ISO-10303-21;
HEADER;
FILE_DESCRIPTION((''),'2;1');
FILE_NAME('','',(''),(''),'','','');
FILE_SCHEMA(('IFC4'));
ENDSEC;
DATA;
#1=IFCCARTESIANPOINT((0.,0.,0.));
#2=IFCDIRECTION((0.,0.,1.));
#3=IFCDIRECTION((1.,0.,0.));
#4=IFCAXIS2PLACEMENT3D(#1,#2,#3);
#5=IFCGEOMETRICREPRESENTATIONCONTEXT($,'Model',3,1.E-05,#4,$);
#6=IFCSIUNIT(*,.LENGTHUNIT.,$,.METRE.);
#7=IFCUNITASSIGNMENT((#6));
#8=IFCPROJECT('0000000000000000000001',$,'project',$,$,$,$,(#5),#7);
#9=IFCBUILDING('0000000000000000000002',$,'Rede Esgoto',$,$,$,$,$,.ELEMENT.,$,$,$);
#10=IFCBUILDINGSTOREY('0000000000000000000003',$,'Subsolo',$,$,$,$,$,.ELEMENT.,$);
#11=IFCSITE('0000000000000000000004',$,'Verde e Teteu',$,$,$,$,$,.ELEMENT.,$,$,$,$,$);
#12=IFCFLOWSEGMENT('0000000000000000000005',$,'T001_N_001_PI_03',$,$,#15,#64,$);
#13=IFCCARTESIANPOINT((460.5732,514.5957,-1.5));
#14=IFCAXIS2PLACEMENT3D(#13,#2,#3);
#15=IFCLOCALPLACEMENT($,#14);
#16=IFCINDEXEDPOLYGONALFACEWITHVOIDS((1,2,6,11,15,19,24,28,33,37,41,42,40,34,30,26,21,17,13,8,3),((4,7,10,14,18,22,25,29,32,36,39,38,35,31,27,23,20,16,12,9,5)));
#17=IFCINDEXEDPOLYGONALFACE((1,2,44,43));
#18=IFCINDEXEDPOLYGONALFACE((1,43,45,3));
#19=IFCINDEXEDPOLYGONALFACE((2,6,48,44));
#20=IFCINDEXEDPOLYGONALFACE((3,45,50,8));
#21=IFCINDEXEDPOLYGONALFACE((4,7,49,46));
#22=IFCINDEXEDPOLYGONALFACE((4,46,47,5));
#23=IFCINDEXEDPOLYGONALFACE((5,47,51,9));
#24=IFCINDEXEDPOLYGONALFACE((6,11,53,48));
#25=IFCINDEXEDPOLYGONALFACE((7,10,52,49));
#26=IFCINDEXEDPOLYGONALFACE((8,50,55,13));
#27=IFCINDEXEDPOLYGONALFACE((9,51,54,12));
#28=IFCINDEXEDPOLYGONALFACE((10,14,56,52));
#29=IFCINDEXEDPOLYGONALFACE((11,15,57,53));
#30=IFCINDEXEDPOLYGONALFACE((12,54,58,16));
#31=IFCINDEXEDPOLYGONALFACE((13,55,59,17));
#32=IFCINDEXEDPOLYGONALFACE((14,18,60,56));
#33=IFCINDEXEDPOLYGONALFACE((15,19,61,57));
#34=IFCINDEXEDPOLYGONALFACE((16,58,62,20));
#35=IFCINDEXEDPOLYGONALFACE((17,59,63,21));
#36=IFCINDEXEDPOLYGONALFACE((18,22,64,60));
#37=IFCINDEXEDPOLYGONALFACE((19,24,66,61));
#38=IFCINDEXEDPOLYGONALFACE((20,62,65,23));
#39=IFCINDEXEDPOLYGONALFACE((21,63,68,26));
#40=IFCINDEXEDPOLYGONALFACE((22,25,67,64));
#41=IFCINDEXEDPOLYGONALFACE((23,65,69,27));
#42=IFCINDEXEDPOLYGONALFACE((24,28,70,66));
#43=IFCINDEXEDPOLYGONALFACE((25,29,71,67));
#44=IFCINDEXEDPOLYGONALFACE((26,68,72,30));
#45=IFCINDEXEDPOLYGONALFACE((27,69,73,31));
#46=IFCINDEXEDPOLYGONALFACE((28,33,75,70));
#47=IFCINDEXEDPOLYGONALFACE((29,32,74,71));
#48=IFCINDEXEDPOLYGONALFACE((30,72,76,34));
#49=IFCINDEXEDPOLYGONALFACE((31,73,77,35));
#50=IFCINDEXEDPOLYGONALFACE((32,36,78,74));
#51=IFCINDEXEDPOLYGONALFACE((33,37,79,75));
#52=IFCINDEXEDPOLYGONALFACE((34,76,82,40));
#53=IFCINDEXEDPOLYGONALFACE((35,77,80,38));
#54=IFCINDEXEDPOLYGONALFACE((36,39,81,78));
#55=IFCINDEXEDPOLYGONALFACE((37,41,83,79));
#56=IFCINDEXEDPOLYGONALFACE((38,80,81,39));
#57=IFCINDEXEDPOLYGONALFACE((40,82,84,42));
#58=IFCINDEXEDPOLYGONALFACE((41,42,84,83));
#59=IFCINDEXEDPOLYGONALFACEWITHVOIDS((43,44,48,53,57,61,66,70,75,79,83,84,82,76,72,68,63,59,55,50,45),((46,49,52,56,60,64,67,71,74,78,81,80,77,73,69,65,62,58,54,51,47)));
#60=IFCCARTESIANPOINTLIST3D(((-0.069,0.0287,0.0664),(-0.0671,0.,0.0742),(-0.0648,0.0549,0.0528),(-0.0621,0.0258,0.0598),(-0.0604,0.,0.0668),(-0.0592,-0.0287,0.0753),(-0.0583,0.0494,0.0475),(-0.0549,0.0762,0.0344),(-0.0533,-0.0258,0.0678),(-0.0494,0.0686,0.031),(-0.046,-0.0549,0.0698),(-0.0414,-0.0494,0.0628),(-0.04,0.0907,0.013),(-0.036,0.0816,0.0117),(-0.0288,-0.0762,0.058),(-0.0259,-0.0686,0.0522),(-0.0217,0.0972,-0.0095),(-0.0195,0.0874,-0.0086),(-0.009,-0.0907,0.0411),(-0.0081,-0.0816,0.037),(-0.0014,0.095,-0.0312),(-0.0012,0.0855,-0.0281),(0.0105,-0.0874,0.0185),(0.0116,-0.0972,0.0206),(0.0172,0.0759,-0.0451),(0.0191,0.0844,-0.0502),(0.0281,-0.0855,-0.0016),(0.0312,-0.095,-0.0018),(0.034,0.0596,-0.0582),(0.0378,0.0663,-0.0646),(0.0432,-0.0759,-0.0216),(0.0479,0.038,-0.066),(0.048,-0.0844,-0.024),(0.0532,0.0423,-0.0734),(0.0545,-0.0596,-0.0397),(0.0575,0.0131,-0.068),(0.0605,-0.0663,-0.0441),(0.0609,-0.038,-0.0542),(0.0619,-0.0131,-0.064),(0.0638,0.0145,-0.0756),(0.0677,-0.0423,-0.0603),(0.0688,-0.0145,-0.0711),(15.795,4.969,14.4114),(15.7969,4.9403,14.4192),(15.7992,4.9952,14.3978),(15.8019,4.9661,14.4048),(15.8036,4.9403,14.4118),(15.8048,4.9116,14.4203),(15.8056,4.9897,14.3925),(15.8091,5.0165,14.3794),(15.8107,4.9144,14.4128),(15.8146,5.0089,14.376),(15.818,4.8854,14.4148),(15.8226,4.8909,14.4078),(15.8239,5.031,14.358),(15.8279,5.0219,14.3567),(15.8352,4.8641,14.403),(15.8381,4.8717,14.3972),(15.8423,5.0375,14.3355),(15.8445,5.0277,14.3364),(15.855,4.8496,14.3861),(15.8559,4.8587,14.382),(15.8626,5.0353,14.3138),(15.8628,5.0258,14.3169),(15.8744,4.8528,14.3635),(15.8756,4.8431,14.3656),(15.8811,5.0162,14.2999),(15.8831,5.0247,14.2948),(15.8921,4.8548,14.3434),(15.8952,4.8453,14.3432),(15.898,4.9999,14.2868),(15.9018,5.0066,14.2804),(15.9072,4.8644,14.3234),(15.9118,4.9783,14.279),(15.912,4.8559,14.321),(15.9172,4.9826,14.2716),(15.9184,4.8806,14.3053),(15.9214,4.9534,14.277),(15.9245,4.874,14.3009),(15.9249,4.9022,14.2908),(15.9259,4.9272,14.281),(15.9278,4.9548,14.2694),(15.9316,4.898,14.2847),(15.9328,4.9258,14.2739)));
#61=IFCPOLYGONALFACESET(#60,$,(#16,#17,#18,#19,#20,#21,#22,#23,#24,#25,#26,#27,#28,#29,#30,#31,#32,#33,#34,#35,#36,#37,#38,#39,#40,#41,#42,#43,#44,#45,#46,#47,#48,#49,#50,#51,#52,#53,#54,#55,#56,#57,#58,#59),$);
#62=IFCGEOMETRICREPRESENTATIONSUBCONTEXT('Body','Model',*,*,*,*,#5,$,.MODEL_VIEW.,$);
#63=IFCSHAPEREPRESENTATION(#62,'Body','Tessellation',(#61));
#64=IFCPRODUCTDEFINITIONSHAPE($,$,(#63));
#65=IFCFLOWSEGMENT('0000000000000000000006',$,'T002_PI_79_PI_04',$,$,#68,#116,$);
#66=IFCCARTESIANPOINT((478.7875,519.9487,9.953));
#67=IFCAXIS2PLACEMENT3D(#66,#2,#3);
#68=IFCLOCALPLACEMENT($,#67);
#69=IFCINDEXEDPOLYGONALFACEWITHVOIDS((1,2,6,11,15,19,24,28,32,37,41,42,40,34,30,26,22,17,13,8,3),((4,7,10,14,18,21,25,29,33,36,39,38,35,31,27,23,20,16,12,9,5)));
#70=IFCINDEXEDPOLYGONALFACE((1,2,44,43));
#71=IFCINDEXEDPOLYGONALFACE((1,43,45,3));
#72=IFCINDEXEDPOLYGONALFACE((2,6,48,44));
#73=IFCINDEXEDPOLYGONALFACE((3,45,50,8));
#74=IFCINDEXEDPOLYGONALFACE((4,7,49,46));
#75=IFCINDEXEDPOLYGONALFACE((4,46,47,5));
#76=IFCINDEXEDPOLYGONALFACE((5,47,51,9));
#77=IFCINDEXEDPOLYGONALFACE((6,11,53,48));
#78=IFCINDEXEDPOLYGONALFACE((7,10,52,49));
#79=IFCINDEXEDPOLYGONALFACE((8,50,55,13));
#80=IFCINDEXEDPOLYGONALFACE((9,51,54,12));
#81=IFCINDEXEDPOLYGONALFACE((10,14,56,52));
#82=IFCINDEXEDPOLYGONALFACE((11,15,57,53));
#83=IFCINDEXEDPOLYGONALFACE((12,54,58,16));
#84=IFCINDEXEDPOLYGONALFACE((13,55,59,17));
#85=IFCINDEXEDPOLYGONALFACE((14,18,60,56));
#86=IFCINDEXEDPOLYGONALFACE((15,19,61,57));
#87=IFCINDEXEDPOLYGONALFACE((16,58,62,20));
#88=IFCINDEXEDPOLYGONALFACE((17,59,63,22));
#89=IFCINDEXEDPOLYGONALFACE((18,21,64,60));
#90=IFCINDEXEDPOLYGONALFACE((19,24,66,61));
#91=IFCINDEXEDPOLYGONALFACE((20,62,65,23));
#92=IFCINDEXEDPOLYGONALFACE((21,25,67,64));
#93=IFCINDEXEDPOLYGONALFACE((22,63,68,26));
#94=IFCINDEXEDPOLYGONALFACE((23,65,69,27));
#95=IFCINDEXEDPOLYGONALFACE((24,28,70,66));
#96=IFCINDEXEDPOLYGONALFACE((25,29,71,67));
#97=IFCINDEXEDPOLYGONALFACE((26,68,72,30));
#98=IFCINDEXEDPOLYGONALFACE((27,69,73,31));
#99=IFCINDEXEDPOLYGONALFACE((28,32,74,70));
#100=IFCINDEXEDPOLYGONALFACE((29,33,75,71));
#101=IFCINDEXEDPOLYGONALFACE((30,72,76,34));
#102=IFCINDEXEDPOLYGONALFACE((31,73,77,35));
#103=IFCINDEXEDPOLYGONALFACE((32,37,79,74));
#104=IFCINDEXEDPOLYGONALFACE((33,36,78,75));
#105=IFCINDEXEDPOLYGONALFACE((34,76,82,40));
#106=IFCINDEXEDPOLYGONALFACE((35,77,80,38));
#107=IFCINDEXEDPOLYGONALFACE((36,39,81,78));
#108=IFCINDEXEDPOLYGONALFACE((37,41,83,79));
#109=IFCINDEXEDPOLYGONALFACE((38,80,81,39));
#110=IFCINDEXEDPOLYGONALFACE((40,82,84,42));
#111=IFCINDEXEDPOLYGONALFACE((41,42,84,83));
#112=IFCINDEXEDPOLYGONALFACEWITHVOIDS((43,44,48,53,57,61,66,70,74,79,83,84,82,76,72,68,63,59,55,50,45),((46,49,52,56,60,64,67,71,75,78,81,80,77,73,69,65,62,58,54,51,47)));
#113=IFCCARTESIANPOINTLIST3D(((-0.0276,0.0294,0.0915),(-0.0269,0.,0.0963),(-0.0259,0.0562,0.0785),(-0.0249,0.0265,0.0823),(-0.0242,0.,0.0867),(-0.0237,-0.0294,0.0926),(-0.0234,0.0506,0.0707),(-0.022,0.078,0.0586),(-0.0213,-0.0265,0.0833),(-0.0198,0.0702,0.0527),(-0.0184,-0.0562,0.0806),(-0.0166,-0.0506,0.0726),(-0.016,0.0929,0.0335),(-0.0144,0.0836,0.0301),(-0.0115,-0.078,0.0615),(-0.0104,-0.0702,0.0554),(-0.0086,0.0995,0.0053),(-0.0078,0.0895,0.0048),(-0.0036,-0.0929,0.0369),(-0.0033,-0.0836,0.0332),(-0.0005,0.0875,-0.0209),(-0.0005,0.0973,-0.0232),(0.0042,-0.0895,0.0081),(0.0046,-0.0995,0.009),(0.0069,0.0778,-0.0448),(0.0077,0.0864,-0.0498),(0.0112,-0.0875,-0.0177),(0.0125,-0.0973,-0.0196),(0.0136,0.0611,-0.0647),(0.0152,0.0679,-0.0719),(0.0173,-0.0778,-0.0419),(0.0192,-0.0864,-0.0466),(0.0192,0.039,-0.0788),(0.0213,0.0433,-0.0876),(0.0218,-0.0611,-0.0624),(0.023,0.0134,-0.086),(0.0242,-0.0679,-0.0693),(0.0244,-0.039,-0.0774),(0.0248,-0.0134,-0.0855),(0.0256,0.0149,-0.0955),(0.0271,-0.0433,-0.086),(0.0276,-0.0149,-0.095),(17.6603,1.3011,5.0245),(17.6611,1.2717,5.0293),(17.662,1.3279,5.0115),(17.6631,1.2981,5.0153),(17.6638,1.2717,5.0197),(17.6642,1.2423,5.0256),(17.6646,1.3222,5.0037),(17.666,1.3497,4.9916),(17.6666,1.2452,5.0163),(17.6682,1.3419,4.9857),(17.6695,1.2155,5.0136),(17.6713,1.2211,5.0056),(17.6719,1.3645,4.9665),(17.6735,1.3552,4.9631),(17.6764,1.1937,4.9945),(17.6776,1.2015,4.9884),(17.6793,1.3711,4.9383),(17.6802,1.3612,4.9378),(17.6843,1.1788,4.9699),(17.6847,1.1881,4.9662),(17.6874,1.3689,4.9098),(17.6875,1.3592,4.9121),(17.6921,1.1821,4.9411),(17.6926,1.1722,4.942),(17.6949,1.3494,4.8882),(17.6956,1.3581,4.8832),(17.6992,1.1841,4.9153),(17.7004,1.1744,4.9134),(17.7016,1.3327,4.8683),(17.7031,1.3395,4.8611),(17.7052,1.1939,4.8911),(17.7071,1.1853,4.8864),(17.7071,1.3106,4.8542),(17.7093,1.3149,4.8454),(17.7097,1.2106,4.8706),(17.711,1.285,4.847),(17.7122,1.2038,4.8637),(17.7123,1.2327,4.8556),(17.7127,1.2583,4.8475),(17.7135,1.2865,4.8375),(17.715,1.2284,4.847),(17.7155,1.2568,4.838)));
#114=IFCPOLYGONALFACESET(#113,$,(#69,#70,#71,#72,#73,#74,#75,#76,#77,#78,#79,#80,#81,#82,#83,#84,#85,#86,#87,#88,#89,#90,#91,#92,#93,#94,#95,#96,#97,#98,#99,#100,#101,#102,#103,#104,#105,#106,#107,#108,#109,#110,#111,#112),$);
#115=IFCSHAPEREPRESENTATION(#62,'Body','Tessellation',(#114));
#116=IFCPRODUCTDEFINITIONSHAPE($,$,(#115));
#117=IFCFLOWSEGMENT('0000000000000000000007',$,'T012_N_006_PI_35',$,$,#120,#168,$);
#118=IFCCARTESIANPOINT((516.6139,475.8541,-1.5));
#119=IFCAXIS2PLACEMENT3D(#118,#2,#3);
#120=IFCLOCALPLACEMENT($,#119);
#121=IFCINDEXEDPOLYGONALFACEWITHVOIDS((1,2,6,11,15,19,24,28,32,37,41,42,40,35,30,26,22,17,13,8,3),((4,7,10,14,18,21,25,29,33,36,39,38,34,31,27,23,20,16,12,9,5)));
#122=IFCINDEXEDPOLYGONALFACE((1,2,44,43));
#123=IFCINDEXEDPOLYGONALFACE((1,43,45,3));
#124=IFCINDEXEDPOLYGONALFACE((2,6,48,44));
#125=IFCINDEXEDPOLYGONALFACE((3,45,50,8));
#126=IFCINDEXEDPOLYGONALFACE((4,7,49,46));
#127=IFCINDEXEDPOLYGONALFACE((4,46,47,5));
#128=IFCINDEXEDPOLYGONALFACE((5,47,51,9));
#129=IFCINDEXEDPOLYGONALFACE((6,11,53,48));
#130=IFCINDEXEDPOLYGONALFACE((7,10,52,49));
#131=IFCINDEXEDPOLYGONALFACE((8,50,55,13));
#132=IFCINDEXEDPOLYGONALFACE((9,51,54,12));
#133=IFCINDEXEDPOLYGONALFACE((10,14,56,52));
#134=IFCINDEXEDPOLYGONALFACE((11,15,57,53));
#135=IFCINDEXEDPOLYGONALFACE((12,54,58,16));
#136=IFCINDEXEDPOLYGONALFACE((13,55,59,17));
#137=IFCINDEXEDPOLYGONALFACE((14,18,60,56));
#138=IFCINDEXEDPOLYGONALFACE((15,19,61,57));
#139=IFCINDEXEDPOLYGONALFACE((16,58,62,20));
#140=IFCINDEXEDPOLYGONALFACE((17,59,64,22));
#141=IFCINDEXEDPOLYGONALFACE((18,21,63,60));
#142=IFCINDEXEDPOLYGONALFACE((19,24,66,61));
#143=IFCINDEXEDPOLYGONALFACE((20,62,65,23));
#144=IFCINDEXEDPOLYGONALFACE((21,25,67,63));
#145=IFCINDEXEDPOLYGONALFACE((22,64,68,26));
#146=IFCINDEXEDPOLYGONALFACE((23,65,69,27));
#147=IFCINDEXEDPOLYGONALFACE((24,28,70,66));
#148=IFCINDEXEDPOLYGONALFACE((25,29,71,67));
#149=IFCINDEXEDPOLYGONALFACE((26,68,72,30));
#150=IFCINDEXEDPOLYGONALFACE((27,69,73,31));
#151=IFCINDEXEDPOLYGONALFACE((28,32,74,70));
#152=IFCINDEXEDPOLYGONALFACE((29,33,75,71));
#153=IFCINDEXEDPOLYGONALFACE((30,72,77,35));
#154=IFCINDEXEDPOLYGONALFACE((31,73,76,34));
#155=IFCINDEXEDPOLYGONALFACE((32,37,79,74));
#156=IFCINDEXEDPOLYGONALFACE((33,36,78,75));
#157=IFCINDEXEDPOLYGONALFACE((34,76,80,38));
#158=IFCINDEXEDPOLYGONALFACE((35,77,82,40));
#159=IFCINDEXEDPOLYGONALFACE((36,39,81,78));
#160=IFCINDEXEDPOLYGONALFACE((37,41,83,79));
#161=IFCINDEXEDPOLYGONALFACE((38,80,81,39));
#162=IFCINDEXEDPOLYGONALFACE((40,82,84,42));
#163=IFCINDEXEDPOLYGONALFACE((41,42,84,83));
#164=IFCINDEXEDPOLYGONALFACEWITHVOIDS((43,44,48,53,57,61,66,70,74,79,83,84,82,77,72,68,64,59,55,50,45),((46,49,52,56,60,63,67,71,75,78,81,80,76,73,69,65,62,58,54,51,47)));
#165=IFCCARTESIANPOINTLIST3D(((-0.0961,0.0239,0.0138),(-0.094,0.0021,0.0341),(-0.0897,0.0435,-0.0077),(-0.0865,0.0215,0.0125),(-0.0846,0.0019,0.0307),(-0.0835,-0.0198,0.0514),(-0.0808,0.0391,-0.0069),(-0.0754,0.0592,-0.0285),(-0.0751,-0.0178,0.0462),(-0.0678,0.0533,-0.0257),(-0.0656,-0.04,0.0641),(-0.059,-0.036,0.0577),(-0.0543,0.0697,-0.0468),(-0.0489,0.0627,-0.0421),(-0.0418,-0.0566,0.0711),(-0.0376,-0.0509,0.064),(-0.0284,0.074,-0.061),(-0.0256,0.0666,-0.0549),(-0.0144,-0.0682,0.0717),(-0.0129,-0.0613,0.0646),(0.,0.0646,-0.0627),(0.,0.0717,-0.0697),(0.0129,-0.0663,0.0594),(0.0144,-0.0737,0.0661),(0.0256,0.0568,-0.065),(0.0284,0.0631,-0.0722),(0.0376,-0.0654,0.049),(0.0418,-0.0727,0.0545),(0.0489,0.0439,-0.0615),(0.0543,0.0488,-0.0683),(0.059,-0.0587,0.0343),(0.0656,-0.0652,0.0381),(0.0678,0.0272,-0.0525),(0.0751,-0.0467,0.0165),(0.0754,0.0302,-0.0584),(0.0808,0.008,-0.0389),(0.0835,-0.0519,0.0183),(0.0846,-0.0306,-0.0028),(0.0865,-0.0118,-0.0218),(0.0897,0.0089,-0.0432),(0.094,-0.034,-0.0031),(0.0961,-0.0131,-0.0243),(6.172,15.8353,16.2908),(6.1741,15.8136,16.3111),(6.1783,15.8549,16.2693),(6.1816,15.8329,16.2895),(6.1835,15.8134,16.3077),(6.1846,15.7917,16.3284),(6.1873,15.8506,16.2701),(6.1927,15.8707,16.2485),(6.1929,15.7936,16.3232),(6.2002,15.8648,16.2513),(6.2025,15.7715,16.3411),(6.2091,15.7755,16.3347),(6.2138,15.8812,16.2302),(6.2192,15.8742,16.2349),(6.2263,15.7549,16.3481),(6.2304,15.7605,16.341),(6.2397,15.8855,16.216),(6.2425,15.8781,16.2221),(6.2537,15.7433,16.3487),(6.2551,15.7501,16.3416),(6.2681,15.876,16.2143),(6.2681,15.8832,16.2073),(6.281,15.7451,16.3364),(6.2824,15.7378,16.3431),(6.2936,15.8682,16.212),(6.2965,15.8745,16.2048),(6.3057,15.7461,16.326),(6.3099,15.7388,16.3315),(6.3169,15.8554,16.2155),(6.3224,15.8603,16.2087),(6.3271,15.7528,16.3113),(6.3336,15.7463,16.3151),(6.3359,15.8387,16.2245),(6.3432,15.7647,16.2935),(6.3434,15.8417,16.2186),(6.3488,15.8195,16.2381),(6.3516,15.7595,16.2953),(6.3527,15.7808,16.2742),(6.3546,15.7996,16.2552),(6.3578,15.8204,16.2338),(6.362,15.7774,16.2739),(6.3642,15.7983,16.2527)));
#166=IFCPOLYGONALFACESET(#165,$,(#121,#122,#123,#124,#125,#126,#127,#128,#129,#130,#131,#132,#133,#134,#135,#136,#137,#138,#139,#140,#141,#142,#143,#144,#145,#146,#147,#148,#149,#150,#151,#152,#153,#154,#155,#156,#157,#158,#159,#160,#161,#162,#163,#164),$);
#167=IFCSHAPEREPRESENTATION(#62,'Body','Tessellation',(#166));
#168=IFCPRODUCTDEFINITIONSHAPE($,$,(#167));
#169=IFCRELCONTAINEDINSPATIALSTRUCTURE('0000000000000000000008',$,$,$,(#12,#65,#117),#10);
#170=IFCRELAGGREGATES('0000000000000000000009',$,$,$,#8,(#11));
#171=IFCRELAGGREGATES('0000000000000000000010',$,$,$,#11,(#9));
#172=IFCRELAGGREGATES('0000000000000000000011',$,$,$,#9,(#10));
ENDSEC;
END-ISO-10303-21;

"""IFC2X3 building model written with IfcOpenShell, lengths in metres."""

from ifc_helpers import new_model, entity, si_unit, frame, origin_with_axes, place, context, subcontext, project, spatial, element, save


model = new_model("IFC2X3")

# Units and contexts
model_context = context("Model", 3, precision=1e-05, world=origin_with_axes())
body_context = subcontext(model_context, "Body", "Model", "MODEL_VIEW")
ifc_project = project(units=[si_unit("LENGTHUNIT", "METRE")], contexts=[model_context])

# Site, building, storey
site = spatial("IfcSite", under=ifc_project, Name="Verde e Teteu", CompositionType="ELEMENT")
building = spatial("IfcBuilding", under=site, Name="Rede Esgoto", CompositionType="ELEMENT")
storey = spatial("IfcBuildingStorey", under=building, Name="Subsolo", CompositionType="ELEMENT")

# Flow segments
flow_segment_1_placement = place(None, frame((460.5732, 514.5957, -1.5), z_axis=(0.0, 0.0, 1.0), x_axis=(1.0, 0.0, 0.0)))
element("IfcFlowSegment", 1, at=flow_segment_1_placement, inside=storey, Name="T001_N_001_PI_03", context=body_context, shape_type="SweptSolid", body=[
    entity("IfcSweptDiskSolid", entity("IfcPolyline", [entity("IfcCartesianPoint", [0.0, 0.0, 0.0]), entity("IfcCartesianPoint", [15.864, 4.9403, 14.345])]), 0.1, 0.09),
])
flow_segment_2_placement = place(None, frame((478.7875, 519.9487, 9.953), z_axis=(0.0, 0.0, 1.0), x_axis=(1.0, 0.0, 0.0)))
element("IfcFlowSegment", 2, at=flow_segment_2_placement, inside=storey, Name="T002_PI_79_PI_04", context=body_context, shape_type="SweptSolid", body=[
    entity("IfcSweptDiskSolid", entity("IfcPolyline", [entity("IfcCartesianPoint", [0.0, 0.0, 0.0]), entity("IfcCartesianPoint", [17.6879, 1.2717, 4.933])]), 0.1, 0.09),
])
flow_segment_3_placement = place(None, frame((516.6139, 475.8541, -1.5), z_axis=(0.0, 0.0, 1.0), x_axis=(1.0, 0.0, 0.0)))
element("IfcFlowSegment", 3, at=flow_segment_3_placement, inside=storey, Name="T012_N_006_PI_35", context=body_context, shape_type="SweptSolid", body=[
    entity("IfcSweptDiskSolid", entity("IfcPolyline", [entity("IfcCartesianPoint", [0.0, 0.0, 0.0]), entity("IfcCartesianPoint", [6.2681, 15.8115, 16.277])]), 0.1, 0.09),
])

save(model, "model.ifc")
